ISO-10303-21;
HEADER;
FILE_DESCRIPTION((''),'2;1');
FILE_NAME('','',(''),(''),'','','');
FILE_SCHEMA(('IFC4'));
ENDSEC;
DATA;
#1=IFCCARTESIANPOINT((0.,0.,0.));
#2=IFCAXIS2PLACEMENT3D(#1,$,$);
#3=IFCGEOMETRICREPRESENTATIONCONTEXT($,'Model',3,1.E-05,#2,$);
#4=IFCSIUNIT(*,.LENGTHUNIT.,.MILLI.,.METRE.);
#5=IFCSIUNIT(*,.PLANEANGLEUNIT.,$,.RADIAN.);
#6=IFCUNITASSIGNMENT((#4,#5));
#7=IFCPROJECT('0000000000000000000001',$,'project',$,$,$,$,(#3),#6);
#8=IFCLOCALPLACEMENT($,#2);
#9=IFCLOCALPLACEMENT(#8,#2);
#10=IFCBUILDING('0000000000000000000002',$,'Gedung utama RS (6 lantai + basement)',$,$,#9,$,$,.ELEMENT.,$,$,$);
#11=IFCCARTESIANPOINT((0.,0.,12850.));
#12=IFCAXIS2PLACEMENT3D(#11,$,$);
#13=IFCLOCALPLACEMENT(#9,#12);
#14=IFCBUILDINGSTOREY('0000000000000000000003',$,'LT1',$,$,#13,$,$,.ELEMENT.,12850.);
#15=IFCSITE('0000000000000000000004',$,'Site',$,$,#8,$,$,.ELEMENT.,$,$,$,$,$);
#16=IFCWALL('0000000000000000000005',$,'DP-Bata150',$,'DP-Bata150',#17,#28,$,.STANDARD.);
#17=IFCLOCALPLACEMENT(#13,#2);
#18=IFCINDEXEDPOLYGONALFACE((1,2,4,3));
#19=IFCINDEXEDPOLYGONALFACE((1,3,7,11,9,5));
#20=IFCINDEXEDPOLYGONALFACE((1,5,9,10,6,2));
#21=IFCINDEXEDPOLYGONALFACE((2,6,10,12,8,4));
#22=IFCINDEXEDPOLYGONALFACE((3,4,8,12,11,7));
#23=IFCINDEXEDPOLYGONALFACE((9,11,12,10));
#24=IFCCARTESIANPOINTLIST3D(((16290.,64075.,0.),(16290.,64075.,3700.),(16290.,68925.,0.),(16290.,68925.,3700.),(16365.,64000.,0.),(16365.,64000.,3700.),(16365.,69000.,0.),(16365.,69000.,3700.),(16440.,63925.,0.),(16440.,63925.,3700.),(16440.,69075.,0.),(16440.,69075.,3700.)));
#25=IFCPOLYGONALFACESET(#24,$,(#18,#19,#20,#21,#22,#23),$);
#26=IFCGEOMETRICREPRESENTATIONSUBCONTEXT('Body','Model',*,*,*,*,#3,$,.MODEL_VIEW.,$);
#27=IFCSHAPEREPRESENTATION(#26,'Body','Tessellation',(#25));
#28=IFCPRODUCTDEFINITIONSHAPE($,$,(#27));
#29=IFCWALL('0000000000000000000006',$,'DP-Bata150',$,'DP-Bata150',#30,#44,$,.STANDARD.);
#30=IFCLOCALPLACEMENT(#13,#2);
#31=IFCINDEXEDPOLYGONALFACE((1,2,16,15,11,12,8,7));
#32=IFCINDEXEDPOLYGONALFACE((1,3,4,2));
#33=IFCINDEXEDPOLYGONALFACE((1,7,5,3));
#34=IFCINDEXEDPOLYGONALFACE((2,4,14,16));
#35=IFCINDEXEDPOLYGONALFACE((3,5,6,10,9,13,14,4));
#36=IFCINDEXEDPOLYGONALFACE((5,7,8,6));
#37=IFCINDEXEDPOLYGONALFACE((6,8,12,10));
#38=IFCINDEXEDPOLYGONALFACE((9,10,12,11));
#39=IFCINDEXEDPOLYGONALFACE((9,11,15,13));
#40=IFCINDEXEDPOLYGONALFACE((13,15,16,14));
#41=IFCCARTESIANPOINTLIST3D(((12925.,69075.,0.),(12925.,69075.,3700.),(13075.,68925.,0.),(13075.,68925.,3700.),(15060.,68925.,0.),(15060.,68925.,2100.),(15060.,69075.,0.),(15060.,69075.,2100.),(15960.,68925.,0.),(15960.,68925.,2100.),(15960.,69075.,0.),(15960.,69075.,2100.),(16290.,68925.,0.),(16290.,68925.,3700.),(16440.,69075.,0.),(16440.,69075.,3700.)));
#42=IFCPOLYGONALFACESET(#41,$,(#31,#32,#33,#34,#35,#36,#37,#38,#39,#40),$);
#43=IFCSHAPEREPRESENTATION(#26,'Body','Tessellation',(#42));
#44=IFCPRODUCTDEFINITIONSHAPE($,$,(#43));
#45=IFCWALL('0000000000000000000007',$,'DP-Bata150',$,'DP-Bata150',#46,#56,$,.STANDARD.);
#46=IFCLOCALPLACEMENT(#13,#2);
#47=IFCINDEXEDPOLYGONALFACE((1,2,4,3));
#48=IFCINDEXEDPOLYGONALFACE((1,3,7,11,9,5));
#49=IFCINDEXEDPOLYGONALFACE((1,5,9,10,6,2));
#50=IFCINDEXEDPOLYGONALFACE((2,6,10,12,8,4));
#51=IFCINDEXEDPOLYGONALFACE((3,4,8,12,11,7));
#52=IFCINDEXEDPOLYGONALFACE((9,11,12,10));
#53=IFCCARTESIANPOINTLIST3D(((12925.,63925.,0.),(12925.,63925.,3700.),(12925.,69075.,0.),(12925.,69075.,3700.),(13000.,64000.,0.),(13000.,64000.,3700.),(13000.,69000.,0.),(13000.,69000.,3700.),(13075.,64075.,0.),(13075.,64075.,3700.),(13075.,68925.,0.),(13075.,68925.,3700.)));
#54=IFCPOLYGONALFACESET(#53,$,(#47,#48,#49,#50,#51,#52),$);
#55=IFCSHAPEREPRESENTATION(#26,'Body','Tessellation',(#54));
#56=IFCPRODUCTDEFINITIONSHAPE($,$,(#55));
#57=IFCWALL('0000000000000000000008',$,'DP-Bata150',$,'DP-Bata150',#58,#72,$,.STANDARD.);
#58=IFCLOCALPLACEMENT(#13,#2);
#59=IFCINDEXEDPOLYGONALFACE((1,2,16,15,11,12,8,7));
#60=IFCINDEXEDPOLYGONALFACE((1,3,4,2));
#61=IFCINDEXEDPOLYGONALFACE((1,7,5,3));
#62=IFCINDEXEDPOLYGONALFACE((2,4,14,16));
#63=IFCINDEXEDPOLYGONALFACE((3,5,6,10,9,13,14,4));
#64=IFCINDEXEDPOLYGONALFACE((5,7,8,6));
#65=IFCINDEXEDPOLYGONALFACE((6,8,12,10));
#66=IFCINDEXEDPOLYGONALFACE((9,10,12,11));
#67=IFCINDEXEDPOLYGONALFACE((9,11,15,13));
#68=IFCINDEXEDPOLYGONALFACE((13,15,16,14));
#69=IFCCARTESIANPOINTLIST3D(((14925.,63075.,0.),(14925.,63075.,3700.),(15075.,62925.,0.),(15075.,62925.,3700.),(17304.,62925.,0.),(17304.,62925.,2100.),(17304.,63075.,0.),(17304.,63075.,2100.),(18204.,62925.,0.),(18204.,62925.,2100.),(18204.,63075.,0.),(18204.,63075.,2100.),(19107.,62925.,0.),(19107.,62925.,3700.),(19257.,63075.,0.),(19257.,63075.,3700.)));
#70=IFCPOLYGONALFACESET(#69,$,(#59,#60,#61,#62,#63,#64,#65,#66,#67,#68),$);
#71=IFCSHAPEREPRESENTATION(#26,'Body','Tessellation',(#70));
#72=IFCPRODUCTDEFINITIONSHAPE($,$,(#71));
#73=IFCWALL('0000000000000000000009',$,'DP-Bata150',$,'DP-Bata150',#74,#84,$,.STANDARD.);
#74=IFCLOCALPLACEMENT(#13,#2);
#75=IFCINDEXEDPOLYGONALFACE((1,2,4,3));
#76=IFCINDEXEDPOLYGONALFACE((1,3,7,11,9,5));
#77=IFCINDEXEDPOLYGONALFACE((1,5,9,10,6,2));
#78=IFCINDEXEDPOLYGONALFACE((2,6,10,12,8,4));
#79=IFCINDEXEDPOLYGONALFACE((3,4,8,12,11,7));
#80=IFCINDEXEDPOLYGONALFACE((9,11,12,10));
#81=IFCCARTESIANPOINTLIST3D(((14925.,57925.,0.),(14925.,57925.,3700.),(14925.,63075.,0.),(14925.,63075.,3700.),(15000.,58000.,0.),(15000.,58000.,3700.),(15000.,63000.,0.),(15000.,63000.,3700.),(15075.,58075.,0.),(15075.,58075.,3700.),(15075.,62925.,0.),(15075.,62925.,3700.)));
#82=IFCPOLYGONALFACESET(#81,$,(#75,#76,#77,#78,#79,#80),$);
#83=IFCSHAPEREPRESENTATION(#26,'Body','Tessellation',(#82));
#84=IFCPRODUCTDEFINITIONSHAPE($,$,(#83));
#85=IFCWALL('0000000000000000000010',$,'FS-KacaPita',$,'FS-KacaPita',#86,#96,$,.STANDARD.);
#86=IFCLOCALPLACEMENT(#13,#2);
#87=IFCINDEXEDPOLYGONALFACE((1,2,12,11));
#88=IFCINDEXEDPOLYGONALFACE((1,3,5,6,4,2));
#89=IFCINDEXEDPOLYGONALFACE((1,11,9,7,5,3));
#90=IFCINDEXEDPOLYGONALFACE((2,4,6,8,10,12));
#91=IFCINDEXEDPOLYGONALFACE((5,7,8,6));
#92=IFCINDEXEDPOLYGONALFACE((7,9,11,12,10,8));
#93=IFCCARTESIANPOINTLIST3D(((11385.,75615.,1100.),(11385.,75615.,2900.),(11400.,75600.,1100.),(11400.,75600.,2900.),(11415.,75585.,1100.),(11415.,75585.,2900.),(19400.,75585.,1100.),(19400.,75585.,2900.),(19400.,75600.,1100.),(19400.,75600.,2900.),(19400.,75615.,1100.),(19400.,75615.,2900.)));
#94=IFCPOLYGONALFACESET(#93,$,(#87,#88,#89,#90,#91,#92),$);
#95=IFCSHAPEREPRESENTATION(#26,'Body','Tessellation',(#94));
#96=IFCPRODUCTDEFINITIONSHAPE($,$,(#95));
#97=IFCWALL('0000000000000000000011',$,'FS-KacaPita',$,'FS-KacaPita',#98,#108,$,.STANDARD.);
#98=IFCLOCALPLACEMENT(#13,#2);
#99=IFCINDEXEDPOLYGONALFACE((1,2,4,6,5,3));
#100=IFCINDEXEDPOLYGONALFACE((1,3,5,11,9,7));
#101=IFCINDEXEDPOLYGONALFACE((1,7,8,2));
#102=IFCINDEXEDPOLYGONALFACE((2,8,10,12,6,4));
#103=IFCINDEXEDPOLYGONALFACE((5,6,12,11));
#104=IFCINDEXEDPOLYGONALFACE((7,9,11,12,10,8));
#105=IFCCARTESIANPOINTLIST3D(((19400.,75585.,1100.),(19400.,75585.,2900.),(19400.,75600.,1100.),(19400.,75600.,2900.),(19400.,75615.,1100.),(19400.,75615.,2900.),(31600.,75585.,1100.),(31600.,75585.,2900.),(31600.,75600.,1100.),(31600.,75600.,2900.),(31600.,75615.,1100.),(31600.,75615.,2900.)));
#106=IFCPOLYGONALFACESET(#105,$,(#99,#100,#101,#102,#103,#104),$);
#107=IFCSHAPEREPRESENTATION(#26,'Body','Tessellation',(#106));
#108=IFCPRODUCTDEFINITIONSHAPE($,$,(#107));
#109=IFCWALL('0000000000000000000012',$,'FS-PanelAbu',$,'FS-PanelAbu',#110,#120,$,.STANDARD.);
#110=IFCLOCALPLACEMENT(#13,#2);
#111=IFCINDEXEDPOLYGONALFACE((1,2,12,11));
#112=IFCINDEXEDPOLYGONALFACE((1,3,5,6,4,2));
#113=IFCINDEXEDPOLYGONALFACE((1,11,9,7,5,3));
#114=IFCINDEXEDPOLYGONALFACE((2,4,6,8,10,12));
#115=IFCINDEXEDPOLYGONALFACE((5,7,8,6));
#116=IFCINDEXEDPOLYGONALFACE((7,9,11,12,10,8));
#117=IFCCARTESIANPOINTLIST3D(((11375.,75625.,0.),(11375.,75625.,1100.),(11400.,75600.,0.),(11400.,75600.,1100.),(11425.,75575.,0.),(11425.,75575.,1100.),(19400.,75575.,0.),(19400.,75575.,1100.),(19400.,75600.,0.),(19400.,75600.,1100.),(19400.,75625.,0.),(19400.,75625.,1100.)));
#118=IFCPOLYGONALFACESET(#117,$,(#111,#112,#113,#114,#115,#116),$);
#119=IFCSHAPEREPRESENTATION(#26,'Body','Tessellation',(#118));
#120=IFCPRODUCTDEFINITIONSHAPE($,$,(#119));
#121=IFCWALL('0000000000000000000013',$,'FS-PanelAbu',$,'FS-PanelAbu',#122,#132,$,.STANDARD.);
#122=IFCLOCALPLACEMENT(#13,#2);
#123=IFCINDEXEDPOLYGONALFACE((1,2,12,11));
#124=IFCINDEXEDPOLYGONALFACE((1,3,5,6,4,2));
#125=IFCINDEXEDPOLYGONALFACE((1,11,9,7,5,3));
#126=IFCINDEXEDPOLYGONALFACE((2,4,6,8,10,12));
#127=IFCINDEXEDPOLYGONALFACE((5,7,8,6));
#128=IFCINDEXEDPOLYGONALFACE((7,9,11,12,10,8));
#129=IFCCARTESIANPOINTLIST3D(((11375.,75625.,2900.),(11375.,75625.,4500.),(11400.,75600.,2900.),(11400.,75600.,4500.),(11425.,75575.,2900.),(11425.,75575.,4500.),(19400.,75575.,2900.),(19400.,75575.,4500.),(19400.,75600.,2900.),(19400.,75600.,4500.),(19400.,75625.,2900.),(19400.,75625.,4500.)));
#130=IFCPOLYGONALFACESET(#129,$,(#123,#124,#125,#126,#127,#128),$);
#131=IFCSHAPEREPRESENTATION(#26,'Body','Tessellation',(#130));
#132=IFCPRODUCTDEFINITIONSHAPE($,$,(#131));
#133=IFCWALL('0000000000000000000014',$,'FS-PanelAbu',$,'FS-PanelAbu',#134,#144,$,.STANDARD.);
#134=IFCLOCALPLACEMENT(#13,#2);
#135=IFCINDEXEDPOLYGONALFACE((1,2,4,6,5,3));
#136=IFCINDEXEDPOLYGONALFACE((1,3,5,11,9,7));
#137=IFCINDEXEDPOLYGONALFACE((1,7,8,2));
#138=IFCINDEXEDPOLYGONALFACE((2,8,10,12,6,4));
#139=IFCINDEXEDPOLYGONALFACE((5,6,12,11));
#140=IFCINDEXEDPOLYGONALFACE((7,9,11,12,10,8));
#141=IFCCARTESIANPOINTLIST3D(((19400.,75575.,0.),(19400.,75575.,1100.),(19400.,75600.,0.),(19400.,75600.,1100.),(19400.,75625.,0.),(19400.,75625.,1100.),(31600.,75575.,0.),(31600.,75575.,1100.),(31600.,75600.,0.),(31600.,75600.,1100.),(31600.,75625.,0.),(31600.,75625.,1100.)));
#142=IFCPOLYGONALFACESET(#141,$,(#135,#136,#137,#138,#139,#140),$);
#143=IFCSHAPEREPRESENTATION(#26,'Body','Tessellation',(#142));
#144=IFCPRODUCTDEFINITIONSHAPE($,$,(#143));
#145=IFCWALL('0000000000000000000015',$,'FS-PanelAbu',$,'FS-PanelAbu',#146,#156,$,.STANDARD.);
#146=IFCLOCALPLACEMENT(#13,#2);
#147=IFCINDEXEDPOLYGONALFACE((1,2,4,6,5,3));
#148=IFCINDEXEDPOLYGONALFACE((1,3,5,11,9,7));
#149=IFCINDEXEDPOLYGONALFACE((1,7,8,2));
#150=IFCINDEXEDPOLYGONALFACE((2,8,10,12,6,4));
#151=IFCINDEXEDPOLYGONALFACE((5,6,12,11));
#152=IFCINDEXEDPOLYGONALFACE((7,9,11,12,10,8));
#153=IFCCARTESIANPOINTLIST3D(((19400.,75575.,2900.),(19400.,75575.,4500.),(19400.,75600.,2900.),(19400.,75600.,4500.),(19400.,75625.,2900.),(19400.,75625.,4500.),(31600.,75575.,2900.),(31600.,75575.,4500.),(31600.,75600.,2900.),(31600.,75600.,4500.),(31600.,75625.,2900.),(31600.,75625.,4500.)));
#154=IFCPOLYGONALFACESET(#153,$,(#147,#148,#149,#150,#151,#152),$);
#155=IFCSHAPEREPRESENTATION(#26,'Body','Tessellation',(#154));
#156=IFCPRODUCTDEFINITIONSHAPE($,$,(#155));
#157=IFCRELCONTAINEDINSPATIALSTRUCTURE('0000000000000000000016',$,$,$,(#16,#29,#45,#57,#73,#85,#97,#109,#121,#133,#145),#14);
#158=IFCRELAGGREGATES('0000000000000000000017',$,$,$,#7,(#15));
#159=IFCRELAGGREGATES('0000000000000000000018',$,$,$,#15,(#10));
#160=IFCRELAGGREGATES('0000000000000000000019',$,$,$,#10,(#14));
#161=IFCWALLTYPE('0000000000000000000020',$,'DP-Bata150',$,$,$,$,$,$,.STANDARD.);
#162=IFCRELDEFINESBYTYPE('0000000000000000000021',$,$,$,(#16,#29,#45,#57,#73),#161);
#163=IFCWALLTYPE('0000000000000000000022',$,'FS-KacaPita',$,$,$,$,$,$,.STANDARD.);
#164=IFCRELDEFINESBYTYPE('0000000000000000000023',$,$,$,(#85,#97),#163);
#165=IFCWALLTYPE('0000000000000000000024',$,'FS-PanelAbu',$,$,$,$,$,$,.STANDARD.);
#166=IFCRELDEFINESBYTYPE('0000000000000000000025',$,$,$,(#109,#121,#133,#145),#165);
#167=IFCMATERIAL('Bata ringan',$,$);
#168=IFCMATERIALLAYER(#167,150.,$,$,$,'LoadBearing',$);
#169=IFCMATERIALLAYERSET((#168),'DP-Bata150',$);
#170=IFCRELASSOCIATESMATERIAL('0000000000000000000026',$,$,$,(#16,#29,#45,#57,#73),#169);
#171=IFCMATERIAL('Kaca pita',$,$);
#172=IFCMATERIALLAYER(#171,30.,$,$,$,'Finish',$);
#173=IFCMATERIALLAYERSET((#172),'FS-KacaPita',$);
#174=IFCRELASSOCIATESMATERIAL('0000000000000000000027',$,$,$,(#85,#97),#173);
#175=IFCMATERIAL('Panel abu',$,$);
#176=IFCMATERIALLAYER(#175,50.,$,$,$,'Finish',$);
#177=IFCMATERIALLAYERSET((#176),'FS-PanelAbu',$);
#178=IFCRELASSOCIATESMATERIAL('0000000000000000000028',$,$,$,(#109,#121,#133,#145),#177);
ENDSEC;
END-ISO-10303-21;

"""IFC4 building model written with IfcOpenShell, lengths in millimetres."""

from ifc_helpers import new_model, si_unit, frame, frame_2d, origin, place, context, subcontext, project, spatial, polyline, rectangle, outline, extrude, material, layer, layer_set, layer_usage, type_object, element, save


model = new_model("IFC4")

# Units and contexts
model_context = context("Model", 3, precision=1e-05, world=origin())
body_context = subcontext(model_context, "Body", "Model", "MODEL_VIEW")
ifc_project = project(units=[si_unit("LENGTHUNIT", "METRE", prefix="MILLI"), si_unit("PLANEANGLEUNIT", "RADIAN")], contexts=[model_context])

# Site, building, storey
site_placement = place(None, origin())
site = spatial("IfcSite", under=ifc_project, at=site_placement, Name="Site", CompositionType="ELEMENT")
building_placement = place(site_placement, origin())
building = spatial("IfcBuilding", under=site, at=building_placement, Name="Gedung utama RS (6 lantai + basement)", CompositionType="ELEMENT")
storey_placement = place(building_placement, frame((0.0, 0.0, 12850.0)))
storey = spatial("IfcBuildingStorey", under=building, at=storey_placement, Name="LT1", CompositionType="ELEMENT", Elevation=12850.0)

# Shared definitions
ifc_material_1 = material(Name="Bata ringan")

# Shared definitions
ifc_layer_1 = layer(ifc_material_1, 150.0, Category="LoadBearing")
ifc_layer_set_1 = layer_set([ifc_layer_1], Name="DP-Bata150")
ifc_layer_usage_1 = layer_usage(ifc_layer_set_1, "AXIS2", "NEGATIVE", 75.0)
wall_type_1 = type_object("IfcWallType", Name="DP-Bata150", PredefinedType="STANDARD")

# Wall
wall_1_placement = place(storey_placement, frame((16365.0, 64000.0, 0.0), z_axis=(0.0, 0.0, 1.0), x_axis=(0.0, 1.0, 0.0)))
element("IfcWall", 1, at=wall_1_placement, inside=storey, type_object=wall_type_1, material=ifc_layer_usage_1, Name="DP-Bata150", ObjectType="DP-Bata150", PredefinedType="STANDARD", context=body_context, shape_type="SweptSolid", body=[
    extrude(outline(polyline([(-75.0, -75.0), (0.0, 0.0), (75.0, 75.0), (4925.0, 75.0), (5000.0, 0.0), (5075.0, -75.0), (-75.0, -75.0)])), origin(), (0.0, 0.0, 1.0), 3700.0),
])

# Wall, opening
wall_2_placement = place(storey_placement, frame((16365.0, 69000.0, 0.0), z_axis=(0.0, 0.0, 1.0), x_axis=(-1.0, 0.0, 0.0)))
wall_2 = element("IfcWall", 2, at=wall_2_placement, inside=storey, type_object=wall_type_1, material=ifc_layer_usage_1, Name="DP-Bata150", ObjectType="DP-Bata150", PredefinedType="STANDARD", context=body_context, shape_type="SweptSolid", body=[
    extrude(outline(polyline([(-75.0, -75.0), (0.0, 0.0), (75.0, 75.0), (3290.0, 75.0), (3365.0, 0.0), (3440.0, -75.0), (-75.0, -75.0)])), origin(), (0.0, 0.0, 1.0), 3700.0),
])
opening_1_placement = place(wall_2_placement, frame((405.0, 0.0, 0.0), z_axis=(0.0, 0.0, 1.0), x_axis=(1.0, 0.0, 0.0)))
element("IfcOpeningElement", 3, at=opening_1_placement, cuts=wall_2, PredefinedType="OPENING", context=body_context, shape_type="SweptSolid", body=[
    extrude(rectangle(XDim=900.0, YDim=170.0, at=frame_2d((450.0, 0.0))), origin(), (0.0, 0.0, 1.0), 2100.0),
])

# Wall
wall_3_placement = place(storey_placement, frame((13000.0, 69000.0, 0.0), z_axis=(0.0, 0.0, 1.0), x_axis=(0.0, -1.0, 0.0)))
element("IfcWall", 4, at=wall_3_placement, inside=storey, type_object=wall_type_1, material=ifc_layer_usage_1, Name="DP-Bata150", ObjectType="DP-Bata150", PredefinedType="STANDARD", context=body_context, shape_type="SweptSolid", body=[
    extrude(outline(polyline([(-75.0, -75.0), (0.0, 0.0), (75.0, 75.0), (4925.0, 75.0), (5000.0, 0.0), (5075.0, -75.0), (-75.0, -75.0)])), origin(), (0.0, 0.0, 1.0), 3700.0),
])

# Wall, opening
wall_4_placement = place(storey_placement, frame((19182.0, 63000.0, 0.0), z_axis=(0.0, 0.0, 1.0), x_axis=(-1.0, 0.0, 0.0)))
wall_4 = element("IfcWall", 5, at=wall_4_placement, inside=storey, type_object=wall_type_1, material=ifc_layer_usage_1, Name="DP-Bata150", ObjectType="DP-Bata150", PredefinedType="STANDARD", context=body_context, shape_type="SweptSolid", body=[
    extrude(outline(polyline([(-75.0, -75.0), (0.0, 0.0), (75.0, 75.0), (4107.0, 75.0), (4182.0, 0.0), (4257.0, -75.0), (-75.0, -75.0)])), origin(), (0.0, 0.0, 1.0), 3700.0),
])
opening_2_placement = place(wall_4_placement, frame((978.0, 0.0, 0.0), z_axis=(0.0, 0.0, 1.0), x_axis=(1.0, 0.0, 0.0)))
element("IfcOpeningElement", 6, at=opening_2_placement, cuts=wall_4, PredefinedType="OPENING", context=body_context, shape_type="SweptSolid", body=[
    extrude(rectangle(XDim=900.0, YDim=170.0, at=frame_2d((450.0, 0.0))), origin(), (0.0, 0.0, 1.0), 2100.0),
])

# Walls
wall_5_placement = place(storey_placement, frame((15000.0, 63000.0, 0.0), z_axis=(0.0, 0.0, 1.0), x_axis=(0.0, -1.0, 0.0)))
element("IfcWall", 7, at=wall_5_placement, inside=storey, type_object=wall_type_1, material=ifc_layer_usage_1, Name="DP-Bata150", ObjectType="DP-Bata150", PredefinedType="STANDARD", context=body_context, shape_type="SweptSolid", body=[
    extrude(outline(polyline([(-75.0, -75.0), (0.0, 0.0), (75.0, 75.0), (4925.0, 75.0), (5000.0, 0.0), (5075.0, -75.0), (-75.0, -75.0)])), origin(), (0.0, 0.0, 1.0), 3700.0),
])
ifc_material_2 = material(Name="Kaca pita")
ifc_layer_2 = layer(ifc_material_2, 30.0, Category="Finish")
ifc_layer_set_2 = layer_set([ifc_layer_2], Name="FS-KacaPita")
ifc_layer_usage_2 = layer_usage(ifc_layer_set_2, "AXIS2", "NEGATIVE", 15.0)
wall_type_2 = type_object("IfcWallType", Name="FS-KacaPita", PredefinedType="STANDARD")
wall_6_placement = place(storey_placement, frame((11400.0, 75600.0, 1100.0), z_axis=(0.0, 0.0, 1.0), x_axis=(1.0, 0.0, 0.0)))
element("IfcWall", 8, at=wall_6_placement, inside=storey, type_object=wall_type_2, material=ifc_layer_usage_2, Name="FS-KacaPita", ObjectType="FS-KacaPita", PredefinedType="STANDARD", context=body_context, shape_type="SweptSolid", body=[
    extrude(outline(polyline([(15.0, -15.0), (0.0, 0.0), (-15.0, 15.0), (8000.0, 15.0), (8000.0, 0.0), (8000.0, -15.0), (15.0, -15.0)])), origin(), (0.0, 0.0, 1.0), 1800.0),
])
wall_7_placement = place(storey_placement, frame((19400.0, 75600.0, 1100.0), z_axis=(0.0, 0.0, 1.0), x_axis=(1.0, 0.0, 0.0)))
element("IfcWall", 9, at=wall_7_placement, inside=storey, type_object=wall_type_2, material=ifc_layer_usage_2, Name="FS-KacaPita", ObjectType="FS-KacaPita", PredefinedType="STANDARD", context=body_context, shape_type="SweptSolid", body=[
    extrude(outline(polyline([(0.0, -15.0), (0.0, 0.0), (0.0, 15.0), (12200.0, 15.0), (12200.0, 0.0), (12200.0, -15.0), (0.0, -15.0)])), origin(), (0.0, 0.0, 1.0), 1800.0),
])
ifc_material_3 = material(Name="Panel abu")
ifc_layer_3 = layer(ifc_material_3, 50.0, Category="Finish")
ifc_layer_set_3 = layer_set([ifc_layer_3], Name="FS-PanelAbu")
ifc_layer_usage_3 = layer_usage(ifc_layer_set_3, "AXIS2", "NEGATIVE", 25.0)
wall_type_3 = type_object("IfcWallType", Name="FS-PanelAbu", PredefinedType="STANDARD")
wall_8_placement = place(storey_placement, frame((11400.0, 75600.0, 0.0), z_axis=(0.0, 0.0, 1.0), x_axis=(1.0, 0.0, 0.0)))
element("IfcWall", 10, at=wall_8_placement, inside=storey, type_object=wall_type_3, material=ifc_layer_usage_3, Name="FS-PanelAbu", ObjectType="FS-PanelAbu", PredefinedType="STANDARD", context=body_context, shape_type="SweptSolid", body=[
    extrude(outline(polyline([(25.0, -25.0), (0.0, 0.0), (-25.0, 25.0), (8000.0, 25.0), (8000.0, 0.0), (8000.0, -25.0), (25.0, -25.0)])), origin(), (0.0, 0.0, 1.0), 1100.0),
])
wall_9_placement = place(storey_placement, frame((11400.0, 75600.0, 2900.0), z_axis=(0.0, 0.0, 1.0), x_axis=(1.0, 0.0, 0.0)))
element("IfcWall", 11, at=wall_9_placement, inside=storey, type_object=wall_type_3, material=ifc_layer_usage_3, Name="FS-PanelAbu", ObjectType="FS-PanelAbu", PredefinedType="STANDARD", context=body_context, shape_type="SweptSolid", body=[
    extrude(outline(polyline([(25.0, -25.0), (0.0, 0.0), (-25.0, 25.0), (8000.0, 25.0), (8000.0, 0.0), (8000.0, -25.0), (25.0, -25.0)])), origin(), (0.0, 0.0, 1.0), 1600.0),
])
wall_10_placement = place(storey_placement, frame((19400.0, 75600.0, 0.0), z_axis=(0.0, 0.0, 1.0), x_axis=(1.0, 0.0, 0.0)))
element("IfcWall", 12, at=wall_10_placement, inside=storey, type_object=wall_type_3, material=ifc_layer_usage_3, Name="FS-PanelAbu", ObjectType="FS-PanelAbu", PredefinedType="STANDARD", context=body_context, shape_type="SweptSolid", body=[
    extrude(outline(polyline([(0.0, -25.0), (0.0, 0.0), (0.0, 25.0), (12200.0, 25.0), (12200.0, 0.0), (12200.0, -25.0), (0.0, -25.0)])), origin(), (0.0, 0.0, 1.0), 1100.0),
])
wall_11_placement = place(storey_placement, frame((19400.0, 75600.0, 2900.0), z_axis=(0.0, 0.0, 1.0), x_axis=(1.0, 0.0, 0.0)))
element("IfcWall", 13, at=wall_11_placement, inside=storey, type_object=wall_type_3, material=ifc_layer_usage_3, Name="FS-PanelAbu", ObjectType="FS-PanelAbu", PredefinedType="STANDARD", context=body_context, shape_type="SweptSolid", body=[
    extrude(outline(polyline([(0.0, -25.0), (0.0, 0.0), (0.0, 25.0), (12200.0, 25.0), (12200.0, 0.0), (12200.0, -25.0), (0.0, -25.0)])), origin(), (0.0, 0.0, 1.0), 1600.0),
])

save(model, "model.ifc")
